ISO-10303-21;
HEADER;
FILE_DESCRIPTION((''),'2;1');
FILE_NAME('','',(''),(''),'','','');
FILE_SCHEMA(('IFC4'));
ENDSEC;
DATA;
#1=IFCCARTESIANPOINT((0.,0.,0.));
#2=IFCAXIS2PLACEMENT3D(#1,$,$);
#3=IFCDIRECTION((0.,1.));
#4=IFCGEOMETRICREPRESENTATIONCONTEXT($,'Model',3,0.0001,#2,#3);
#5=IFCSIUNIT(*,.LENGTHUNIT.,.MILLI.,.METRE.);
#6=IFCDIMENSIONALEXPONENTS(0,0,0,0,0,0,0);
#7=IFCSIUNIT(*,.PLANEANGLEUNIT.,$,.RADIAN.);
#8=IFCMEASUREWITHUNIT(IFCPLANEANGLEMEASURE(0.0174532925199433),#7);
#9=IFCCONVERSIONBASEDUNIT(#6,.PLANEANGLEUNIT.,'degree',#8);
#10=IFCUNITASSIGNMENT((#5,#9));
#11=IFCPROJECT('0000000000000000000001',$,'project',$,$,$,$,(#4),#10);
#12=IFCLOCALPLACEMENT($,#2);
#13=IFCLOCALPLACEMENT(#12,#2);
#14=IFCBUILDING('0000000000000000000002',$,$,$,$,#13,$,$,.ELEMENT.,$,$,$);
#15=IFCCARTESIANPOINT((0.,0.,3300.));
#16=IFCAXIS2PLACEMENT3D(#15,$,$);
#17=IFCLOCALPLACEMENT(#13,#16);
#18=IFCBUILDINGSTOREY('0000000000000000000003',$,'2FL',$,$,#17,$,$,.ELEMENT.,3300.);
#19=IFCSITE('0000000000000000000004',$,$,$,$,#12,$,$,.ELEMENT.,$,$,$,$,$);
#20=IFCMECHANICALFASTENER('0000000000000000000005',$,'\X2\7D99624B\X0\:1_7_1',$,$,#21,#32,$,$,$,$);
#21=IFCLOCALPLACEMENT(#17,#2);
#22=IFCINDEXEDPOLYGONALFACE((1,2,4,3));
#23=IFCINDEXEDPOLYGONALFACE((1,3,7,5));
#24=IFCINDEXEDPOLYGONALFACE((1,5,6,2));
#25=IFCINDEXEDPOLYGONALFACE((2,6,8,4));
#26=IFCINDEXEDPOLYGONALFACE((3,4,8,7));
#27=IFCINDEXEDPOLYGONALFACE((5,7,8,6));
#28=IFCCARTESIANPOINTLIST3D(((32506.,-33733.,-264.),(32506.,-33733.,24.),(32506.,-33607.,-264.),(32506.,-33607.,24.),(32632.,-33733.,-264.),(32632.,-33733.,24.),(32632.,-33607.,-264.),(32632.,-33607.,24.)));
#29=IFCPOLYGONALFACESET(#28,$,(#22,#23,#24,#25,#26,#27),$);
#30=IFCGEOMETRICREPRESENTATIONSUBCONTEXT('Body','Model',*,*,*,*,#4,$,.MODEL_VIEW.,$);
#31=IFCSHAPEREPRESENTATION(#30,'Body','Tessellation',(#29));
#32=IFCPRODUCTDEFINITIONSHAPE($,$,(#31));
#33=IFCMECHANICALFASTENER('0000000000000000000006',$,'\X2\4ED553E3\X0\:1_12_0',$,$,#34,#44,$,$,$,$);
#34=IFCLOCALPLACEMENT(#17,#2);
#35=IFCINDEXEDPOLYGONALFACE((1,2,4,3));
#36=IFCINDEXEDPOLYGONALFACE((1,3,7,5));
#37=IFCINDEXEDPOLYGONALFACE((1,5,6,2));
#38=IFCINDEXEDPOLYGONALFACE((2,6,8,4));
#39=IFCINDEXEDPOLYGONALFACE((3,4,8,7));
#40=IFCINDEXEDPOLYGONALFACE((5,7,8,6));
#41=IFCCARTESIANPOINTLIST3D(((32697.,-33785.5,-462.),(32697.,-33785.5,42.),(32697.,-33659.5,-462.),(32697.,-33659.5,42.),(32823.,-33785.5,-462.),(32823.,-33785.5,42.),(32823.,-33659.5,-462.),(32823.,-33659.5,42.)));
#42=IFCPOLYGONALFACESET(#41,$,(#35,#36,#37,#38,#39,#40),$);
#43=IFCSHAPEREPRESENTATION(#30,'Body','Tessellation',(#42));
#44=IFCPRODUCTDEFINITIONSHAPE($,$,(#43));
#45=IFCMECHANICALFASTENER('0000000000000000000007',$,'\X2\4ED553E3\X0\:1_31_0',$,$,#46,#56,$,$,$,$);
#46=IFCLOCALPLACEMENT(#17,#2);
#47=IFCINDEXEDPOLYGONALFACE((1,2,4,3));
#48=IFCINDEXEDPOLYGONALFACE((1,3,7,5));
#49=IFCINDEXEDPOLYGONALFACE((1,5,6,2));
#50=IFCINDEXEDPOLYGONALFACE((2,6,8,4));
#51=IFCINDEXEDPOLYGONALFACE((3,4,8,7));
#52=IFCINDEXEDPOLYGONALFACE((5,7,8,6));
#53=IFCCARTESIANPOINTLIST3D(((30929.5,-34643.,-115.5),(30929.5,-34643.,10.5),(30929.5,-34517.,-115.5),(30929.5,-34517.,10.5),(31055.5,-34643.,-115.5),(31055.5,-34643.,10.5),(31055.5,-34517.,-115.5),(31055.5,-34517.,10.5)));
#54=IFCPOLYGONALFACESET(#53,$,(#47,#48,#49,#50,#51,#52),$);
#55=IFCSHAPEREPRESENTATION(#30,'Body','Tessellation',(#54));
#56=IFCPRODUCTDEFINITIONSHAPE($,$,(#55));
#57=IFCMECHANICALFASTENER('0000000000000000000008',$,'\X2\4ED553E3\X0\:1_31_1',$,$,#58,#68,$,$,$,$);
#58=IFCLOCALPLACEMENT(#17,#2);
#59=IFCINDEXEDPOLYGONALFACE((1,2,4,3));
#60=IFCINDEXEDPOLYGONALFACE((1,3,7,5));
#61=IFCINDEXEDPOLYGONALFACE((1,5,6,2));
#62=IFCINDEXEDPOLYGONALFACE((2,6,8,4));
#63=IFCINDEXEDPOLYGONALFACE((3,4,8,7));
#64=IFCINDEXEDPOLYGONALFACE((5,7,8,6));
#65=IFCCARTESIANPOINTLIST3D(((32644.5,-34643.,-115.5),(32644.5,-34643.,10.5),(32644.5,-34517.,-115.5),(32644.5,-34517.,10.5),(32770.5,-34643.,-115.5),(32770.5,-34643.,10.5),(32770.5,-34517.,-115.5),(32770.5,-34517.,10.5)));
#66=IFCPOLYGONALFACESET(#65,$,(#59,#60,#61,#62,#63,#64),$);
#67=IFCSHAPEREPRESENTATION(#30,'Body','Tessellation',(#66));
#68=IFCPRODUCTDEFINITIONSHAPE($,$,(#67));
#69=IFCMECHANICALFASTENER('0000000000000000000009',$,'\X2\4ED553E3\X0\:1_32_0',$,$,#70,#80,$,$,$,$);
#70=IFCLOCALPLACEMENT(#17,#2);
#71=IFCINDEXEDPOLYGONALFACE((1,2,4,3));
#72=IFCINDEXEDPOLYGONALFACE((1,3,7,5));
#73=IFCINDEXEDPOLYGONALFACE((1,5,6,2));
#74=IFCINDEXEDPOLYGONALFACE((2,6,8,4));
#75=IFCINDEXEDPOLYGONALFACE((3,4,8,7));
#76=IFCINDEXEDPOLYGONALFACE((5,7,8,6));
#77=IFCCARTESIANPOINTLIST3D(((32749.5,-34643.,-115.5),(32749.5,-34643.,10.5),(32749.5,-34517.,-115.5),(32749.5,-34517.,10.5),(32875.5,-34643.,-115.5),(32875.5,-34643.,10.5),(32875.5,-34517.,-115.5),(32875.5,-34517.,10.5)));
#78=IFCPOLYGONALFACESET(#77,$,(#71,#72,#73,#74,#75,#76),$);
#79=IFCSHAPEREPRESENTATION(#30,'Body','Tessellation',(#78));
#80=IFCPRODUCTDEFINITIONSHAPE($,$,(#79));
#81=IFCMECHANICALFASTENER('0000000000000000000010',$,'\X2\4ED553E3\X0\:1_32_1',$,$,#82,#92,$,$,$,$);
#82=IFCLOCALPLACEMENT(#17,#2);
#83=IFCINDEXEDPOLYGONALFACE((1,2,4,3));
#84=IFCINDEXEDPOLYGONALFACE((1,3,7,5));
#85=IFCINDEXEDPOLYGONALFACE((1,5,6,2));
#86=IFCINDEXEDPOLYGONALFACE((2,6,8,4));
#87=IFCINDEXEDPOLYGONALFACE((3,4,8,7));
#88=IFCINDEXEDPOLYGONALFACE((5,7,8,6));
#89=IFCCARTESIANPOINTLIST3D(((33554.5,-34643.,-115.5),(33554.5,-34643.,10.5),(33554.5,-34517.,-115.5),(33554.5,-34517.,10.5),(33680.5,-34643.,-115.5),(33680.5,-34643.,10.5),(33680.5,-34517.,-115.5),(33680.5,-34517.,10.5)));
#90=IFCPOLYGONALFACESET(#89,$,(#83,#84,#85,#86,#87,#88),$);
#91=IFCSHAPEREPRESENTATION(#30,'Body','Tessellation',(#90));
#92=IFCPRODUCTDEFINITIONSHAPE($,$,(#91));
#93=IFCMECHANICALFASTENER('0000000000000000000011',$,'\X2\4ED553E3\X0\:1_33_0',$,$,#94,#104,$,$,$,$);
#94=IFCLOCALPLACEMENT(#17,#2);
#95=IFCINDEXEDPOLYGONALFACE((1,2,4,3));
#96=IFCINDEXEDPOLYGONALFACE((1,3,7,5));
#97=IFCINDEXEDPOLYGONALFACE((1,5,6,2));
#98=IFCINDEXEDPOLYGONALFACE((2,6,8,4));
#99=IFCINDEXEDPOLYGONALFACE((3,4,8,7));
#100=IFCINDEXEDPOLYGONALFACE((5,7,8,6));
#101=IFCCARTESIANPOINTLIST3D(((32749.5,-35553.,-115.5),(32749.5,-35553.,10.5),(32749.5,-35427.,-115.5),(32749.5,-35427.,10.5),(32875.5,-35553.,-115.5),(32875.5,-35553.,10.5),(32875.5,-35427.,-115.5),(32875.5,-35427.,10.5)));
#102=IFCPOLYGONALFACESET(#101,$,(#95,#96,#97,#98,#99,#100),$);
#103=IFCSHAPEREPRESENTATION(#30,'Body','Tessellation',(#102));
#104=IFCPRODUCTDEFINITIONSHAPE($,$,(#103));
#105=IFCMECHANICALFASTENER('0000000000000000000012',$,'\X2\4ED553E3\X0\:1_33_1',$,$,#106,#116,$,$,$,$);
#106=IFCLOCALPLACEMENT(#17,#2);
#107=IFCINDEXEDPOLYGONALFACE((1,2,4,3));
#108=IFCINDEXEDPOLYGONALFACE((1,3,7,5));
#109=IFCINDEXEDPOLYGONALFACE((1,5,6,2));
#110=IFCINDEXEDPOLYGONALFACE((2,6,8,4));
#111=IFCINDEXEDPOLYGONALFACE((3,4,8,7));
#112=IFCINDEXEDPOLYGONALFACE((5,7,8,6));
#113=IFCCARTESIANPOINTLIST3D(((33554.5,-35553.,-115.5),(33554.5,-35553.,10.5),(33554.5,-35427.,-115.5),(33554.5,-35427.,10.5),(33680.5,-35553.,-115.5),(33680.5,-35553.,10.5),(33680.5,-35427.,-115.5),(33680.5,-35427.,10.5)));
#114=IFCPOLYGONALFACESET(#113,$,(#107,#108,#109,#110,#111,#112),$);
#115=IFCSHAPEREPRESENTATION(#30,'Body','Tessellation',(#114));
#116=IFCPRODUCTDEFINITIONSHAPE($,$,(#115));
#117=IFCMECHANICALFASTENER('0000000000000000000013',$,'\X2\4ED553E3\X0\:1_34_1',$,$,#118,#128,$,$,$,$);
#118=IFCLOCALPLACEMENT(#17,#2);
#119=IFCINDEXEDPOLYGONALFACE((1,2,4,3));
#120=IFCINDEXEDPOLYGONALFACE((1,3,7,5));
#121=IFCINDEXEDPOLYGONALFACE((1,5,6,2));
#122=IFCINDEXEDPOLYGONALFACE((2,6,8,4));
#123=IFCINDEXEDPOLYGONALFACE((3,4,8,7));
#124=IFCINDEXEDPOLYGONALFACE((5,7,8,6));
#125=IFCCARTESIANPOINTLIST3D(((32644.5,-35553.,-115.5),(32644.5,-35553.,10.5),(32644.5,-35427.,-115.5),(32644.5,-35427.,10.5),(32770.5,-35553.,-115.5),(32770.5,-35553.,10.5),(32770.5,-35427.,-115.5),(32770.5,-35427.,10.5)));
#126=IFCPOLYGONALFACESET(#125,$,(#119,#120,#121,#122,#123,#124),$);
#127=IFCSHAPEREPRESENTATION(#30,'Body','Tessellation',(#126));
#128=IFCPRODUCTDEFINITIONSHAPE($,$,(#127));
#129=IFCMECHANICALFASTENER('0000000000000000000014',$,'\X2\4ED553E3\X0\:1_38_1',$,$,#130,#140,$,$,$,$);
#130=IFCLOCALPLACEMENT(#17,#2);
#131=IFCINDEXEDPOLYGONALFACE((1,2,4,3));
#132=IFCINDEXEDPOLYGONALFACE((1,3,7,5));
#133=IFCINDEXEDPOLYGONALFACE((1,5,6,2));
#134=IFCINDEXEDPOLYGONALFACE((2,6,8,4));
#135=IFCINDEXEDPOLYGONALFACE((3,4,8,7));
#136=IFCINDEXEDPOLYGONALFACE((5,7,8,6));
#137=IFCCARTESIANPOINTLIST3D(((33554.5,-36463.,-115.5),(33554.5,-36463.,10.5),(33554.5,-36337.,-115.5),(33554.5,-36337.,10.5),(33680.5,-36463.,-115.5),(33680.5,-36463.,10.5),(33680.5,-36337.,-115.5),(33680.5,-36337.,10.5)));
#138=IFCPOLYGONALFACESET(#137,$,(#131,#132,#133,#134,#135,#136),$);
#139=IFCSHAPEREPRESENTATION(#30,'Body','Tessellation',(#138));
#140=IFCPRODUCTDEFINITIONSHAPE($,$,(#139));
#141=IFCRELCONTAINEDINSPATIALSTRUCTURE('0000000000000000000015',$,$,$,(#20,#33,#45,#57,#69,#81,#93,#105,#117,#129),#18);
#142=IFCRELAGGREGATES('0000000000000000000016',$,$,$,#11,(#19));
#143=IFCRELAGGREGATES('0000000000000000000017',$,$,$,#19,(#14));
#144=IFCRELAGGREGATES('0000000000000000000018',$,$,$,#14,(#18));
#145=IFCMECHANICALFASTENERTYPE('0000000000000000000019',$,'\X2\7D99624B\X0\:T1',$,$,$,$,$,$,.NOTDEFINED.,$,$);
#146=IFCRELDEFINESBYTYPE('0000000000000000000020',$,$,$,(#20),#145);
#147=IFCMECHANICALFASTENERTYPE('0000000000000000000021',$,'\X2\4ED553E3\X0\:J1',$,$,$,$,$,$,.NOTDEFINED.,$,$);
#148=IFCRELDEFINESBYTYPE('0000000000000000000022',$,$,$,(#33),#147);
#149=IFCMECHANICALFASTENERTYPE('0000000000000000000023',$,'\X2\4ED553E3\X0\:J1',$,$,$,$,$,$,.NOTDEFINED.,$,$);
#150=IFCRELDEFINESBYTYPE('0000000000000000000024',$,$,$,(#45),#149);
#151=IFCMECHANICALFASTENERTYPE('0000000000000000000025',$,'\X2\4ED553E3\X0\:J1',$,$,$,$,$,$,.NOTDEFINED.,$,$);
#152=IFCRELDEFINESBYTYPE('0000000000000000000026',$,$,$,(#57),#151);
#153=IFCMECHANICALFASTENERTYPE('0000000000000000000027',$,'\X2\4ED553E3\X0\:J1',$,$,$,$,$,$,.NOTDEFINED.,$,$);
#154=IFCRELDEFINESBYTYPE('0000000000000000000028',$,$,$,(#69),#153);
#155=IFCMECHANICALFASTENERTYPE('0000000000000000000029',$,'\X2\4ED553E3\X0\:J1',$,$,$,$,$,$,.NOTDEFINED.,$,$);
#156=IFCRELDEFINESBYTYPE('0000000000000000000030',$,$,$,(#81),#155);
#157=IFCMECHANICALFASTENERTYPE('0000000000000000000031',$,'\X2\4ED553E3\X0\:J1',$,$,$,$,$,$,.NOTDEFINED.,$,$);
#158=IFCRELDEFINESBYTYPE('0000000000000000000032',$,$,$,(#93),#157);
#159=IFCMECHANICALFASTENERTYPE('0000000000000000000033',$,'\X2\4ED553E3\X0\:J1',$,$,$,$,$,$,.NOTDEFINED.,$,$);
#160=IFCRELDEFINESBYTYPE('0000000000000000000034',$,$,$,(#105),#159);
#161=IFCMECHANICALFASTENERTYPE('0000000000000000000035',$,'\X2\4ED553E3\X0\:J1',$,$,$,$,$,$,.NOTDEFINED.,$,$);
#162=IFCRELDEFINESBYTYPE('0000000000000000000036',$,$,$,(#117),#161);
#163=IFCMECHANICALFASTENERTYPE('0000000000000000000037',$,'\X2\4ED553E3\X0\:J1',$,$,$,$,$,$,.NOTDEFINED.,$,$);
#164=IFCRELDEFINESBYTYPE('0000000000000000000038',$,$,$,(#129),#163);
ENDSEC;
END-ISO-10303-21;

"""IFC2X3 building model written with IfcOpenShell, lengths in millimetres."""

from ifc_helpers import new_model, entity, si_unit, converted_unit, direction, frame, origin, origin_with_axes, origin_2d, place, context, subcontext, project, spatial, rectangle, extrude, type_object, element, save


model = new_model("IFC2X3")

# Units and contexts
model_context = context("Model", 3, precision=0.0001, world=origin(), true_north=direction((0.0, 1.0)))
body_context = subcontext(model_context, "Body", "Model", "MODEL_VIEW")
ifc_project = project(units=[si_unit("LENGTHUNIT", "METRE", prefix="MILLI"), converted_unit("PLANEANGLEUNIT", "degree", entity("IfcPlaneAngleMeasure", 0.0174532925199433), si_unit("PLANEANGLEUNIT", "RADIAN"), dimensions=[0, 0, 0, 0, 0, 0, 0])], contexts=[model_context])

# Site, building, storey
site_placement = place(None, origin())
site = spatial("IfcSite", under=ifc_project, at=site_placement, CompositionType="ELEMENT")
building_placement = place(site_placement, origin())
building = spatial("IfcBuilding", under=site, at=building_placement, CompositionType="ELEMENT")
storey_placement = place(building_placement, frame((0.0, 0.0, 3300.0)))
storey = spatial("IfcBuildingStorey", under=building, at=storey_placement, Name="2FL", CompositionType="ELEMENT", Elevation=3300.0)

# Mechanical fasteners
mechanical_fastener_type_1 = type_object("IfcMechanicalFastenerType", Name="継手:T1")
mechanical_fastener_1_placement = place(storey_placement, frame((32569.0, -33670.0, -264.0)))
element("IfcMechanicalFastener", 1, at=mechanical_fastener_1_placement, inside=storey, type_object=mechanical_fastener_type_1, Name="継手:1_7_1", context=body_context, shape_type="SweptSolid", body=[
    extrude(rectangle(XDim=126.0, YDim=126.0, at=origin_2d()), origin_with_axes(), (0.0, 0.0, 1.0), 288.0),
])
mechanical_fastener_type_2 = type_object("IfcMechanicalFastenerType", Name="仕口:J1")
mechanical_fastener_2_placement = place(storey_placement, frame((32760.0, -33722.5, -462.0)))
element("IfcMechanicalFastener", 2, at=mechanical_fastener_2_placement, inside=storey, type_object=mechanical_fastener_type_2, Name="仕口:1_12_0", context=body_context, shape_type="SweptSolid", body=[
    extrude(rectangle(XDim=126.0, YDim=126.0, at=origin_2d()), origin_with_axes(), (0.0, 0.0, 1.0), 504.0),
])
mechanical_fastener_type_3 = type_object("IfcMechanicalFastenerType", Name="仕口:J1")
mechanical_fastener_3_placement = place(storey_placement, frame((30992.5, -34580.0, -115.5)))
element("IfcMechanicalFastener", 3, at=mechanical_fastener_3_placement, inside=storey, type_object=mechanical_fastener_type_3, Name="仕口:1_31_0", context=body_context, shape_type="SweptSolid", body=[
    extrude(rectangle(XDim=126.0, YDim=126.0, at=origin_2d()), origin_with_axes(), (0.0, 0.0, 1.0), 126.0),
])
mechanical_fastener_type_4 = type_object("IfcMechanicalFastenerType", Name="仕口:J1")
mechanical_fastener_4_placement = place(storey_placement, frame((32707.5, -34580.0, -115.5)))
element("IfcMechanicalFastener", 4, at=mechanical_fastener_4_placement, inside=storey, type_object=mechanical_fastener_type_4, Name="仕口:1_31_1", context=body_context, shape_type="SweptSolid", body=[
    extrude(rectangle(XDim=126.0, YDim=126.0, at=origin_2d()), origin_with_axes(), (0.0, 0.0, 1.0), 126.0),
])
mechanical_fastener_type_5 = type_object("IfcMechanicalFastenerType", Name="仕口:J1")
mechanical_fastener_5_placement = place(storey_placement, frame((32812.5, -34580.0, -115.5)))
element("IfcMechanicalFastener", 5, at=mechanical_fastener_5_placement, inside=storey, type_object=mechanical_fastener_type_5, Name="仕口:1_32_0", context=body_context, shape_type="SweptSolid", body=[
    extrude(rectangle(XDim=126.0, YDim=126.0, at=origin_2d()), origin_with_axes(), (0.0, 0.0, 1.0), 126.0),
])
mechanical_fastener_type_6 = type_object("IfcMechanicalFastenerType", Name="仕口:J1")
mechanical_fastener_6_placement = place(storey_placement, frame((33617.5, -34580.0, -115.5)))
element("IfcMechanicalFastener", 6, at=mechanical_fastener_6_placement, inside=storey, type_object=mechanical_fastener_type_6, Name="仕口:1_32_1", context=body_context, shape_type="SweptSolid", body=[
    extrude(rectangle(XDim=126.0, YDim=126.0, at=origin_2d()), origin_with_axes(), (0.0, 0.0, 1.0), 126.0),
])
mechanical_fastener_type_7 = type_object("IfcMechanicalFastenerType", Name="仕口:J1")
mechanical_fastener_7_placement = place(storey_placement, frame((32812.5, -35490.0, -115.5)))
element("IfcMechanicalFastener", 7, at=mechanical_fastener_7_placement, inside=storey, type_object=mechanical_fastener_type_7, Name="仕口:1_33_0", context=body_context, shape_type="SweptSolid", body=[
    extrude(rectangle(XDim=126.0, YDim=126.0, at=origin_2d()), origin_with_axes(), (0.0, 0.0, 1.0), 126.0),
])
mechanical_fastener_type_8 = type_object("IfcMechanicalFastenerType", Name="仕口:J1")
mechanical_fastener_8_placement = place(storey_placement, frame((33617.5, -35490.0, -115.5)))
element("IfcMechanicalFastener", 8, at=mechanical_fastener_8_placement, inside=storey, type_object=mechanical_fastener_type_8, Name="仕口:1_33_1", context=body_context, shape_type="SweptSolid", body=[
    extrude(rectangle(XDim=126.0, YDim=126.0, at=origin_2d()), origin_with_axes(), (0.0, 0.0, 1.0), 126.0),
])
mechanical_fastener_type_9 = type_object("IfcMechanicalFastenerType", Name="仕口:J1")
mechanical_fastener_9_placement = place(storey_placement, frame((32707.5, -35490.0, -115.5)))
element("IfcMechanicalFastener", 9, at=mechanical_fastener_9_placement, inside=storey, type_object=mechanical_fastener_type_9, Name="仕口:1_34_1", context=body_context, shape_type="SweptSolid", body=[
    extrude(rectangle(XDim=126.0, YDim=126.0, at=origin_2d()), origin_with_axes(), (0.0, 0.0, 1.0), 126.0),
])
mechanical_fastener_type_10 = type_object("IfcMechanicalFastenerType", Name="仕口:J1")
mechanical_fastener_10_placement = place(storey_placement, frame((33617.5, -36400.0, -115.5)))
element("IfcMechanicalFastener", 10, at=mechanical_fastener_10_placement, inside=storey, type_object=mechanical_fastener_type_10, Name="仕口:1_38_1", context=body_context, shape_type="SweptSolid", body=[
    extrude(rectangle(XDim=126.0, YDim=126.0, at=origin_2d()), origin_with_axes(), (0.0, 0.0, 1.0), 126.0),
])

save(model, "model.ifc")
